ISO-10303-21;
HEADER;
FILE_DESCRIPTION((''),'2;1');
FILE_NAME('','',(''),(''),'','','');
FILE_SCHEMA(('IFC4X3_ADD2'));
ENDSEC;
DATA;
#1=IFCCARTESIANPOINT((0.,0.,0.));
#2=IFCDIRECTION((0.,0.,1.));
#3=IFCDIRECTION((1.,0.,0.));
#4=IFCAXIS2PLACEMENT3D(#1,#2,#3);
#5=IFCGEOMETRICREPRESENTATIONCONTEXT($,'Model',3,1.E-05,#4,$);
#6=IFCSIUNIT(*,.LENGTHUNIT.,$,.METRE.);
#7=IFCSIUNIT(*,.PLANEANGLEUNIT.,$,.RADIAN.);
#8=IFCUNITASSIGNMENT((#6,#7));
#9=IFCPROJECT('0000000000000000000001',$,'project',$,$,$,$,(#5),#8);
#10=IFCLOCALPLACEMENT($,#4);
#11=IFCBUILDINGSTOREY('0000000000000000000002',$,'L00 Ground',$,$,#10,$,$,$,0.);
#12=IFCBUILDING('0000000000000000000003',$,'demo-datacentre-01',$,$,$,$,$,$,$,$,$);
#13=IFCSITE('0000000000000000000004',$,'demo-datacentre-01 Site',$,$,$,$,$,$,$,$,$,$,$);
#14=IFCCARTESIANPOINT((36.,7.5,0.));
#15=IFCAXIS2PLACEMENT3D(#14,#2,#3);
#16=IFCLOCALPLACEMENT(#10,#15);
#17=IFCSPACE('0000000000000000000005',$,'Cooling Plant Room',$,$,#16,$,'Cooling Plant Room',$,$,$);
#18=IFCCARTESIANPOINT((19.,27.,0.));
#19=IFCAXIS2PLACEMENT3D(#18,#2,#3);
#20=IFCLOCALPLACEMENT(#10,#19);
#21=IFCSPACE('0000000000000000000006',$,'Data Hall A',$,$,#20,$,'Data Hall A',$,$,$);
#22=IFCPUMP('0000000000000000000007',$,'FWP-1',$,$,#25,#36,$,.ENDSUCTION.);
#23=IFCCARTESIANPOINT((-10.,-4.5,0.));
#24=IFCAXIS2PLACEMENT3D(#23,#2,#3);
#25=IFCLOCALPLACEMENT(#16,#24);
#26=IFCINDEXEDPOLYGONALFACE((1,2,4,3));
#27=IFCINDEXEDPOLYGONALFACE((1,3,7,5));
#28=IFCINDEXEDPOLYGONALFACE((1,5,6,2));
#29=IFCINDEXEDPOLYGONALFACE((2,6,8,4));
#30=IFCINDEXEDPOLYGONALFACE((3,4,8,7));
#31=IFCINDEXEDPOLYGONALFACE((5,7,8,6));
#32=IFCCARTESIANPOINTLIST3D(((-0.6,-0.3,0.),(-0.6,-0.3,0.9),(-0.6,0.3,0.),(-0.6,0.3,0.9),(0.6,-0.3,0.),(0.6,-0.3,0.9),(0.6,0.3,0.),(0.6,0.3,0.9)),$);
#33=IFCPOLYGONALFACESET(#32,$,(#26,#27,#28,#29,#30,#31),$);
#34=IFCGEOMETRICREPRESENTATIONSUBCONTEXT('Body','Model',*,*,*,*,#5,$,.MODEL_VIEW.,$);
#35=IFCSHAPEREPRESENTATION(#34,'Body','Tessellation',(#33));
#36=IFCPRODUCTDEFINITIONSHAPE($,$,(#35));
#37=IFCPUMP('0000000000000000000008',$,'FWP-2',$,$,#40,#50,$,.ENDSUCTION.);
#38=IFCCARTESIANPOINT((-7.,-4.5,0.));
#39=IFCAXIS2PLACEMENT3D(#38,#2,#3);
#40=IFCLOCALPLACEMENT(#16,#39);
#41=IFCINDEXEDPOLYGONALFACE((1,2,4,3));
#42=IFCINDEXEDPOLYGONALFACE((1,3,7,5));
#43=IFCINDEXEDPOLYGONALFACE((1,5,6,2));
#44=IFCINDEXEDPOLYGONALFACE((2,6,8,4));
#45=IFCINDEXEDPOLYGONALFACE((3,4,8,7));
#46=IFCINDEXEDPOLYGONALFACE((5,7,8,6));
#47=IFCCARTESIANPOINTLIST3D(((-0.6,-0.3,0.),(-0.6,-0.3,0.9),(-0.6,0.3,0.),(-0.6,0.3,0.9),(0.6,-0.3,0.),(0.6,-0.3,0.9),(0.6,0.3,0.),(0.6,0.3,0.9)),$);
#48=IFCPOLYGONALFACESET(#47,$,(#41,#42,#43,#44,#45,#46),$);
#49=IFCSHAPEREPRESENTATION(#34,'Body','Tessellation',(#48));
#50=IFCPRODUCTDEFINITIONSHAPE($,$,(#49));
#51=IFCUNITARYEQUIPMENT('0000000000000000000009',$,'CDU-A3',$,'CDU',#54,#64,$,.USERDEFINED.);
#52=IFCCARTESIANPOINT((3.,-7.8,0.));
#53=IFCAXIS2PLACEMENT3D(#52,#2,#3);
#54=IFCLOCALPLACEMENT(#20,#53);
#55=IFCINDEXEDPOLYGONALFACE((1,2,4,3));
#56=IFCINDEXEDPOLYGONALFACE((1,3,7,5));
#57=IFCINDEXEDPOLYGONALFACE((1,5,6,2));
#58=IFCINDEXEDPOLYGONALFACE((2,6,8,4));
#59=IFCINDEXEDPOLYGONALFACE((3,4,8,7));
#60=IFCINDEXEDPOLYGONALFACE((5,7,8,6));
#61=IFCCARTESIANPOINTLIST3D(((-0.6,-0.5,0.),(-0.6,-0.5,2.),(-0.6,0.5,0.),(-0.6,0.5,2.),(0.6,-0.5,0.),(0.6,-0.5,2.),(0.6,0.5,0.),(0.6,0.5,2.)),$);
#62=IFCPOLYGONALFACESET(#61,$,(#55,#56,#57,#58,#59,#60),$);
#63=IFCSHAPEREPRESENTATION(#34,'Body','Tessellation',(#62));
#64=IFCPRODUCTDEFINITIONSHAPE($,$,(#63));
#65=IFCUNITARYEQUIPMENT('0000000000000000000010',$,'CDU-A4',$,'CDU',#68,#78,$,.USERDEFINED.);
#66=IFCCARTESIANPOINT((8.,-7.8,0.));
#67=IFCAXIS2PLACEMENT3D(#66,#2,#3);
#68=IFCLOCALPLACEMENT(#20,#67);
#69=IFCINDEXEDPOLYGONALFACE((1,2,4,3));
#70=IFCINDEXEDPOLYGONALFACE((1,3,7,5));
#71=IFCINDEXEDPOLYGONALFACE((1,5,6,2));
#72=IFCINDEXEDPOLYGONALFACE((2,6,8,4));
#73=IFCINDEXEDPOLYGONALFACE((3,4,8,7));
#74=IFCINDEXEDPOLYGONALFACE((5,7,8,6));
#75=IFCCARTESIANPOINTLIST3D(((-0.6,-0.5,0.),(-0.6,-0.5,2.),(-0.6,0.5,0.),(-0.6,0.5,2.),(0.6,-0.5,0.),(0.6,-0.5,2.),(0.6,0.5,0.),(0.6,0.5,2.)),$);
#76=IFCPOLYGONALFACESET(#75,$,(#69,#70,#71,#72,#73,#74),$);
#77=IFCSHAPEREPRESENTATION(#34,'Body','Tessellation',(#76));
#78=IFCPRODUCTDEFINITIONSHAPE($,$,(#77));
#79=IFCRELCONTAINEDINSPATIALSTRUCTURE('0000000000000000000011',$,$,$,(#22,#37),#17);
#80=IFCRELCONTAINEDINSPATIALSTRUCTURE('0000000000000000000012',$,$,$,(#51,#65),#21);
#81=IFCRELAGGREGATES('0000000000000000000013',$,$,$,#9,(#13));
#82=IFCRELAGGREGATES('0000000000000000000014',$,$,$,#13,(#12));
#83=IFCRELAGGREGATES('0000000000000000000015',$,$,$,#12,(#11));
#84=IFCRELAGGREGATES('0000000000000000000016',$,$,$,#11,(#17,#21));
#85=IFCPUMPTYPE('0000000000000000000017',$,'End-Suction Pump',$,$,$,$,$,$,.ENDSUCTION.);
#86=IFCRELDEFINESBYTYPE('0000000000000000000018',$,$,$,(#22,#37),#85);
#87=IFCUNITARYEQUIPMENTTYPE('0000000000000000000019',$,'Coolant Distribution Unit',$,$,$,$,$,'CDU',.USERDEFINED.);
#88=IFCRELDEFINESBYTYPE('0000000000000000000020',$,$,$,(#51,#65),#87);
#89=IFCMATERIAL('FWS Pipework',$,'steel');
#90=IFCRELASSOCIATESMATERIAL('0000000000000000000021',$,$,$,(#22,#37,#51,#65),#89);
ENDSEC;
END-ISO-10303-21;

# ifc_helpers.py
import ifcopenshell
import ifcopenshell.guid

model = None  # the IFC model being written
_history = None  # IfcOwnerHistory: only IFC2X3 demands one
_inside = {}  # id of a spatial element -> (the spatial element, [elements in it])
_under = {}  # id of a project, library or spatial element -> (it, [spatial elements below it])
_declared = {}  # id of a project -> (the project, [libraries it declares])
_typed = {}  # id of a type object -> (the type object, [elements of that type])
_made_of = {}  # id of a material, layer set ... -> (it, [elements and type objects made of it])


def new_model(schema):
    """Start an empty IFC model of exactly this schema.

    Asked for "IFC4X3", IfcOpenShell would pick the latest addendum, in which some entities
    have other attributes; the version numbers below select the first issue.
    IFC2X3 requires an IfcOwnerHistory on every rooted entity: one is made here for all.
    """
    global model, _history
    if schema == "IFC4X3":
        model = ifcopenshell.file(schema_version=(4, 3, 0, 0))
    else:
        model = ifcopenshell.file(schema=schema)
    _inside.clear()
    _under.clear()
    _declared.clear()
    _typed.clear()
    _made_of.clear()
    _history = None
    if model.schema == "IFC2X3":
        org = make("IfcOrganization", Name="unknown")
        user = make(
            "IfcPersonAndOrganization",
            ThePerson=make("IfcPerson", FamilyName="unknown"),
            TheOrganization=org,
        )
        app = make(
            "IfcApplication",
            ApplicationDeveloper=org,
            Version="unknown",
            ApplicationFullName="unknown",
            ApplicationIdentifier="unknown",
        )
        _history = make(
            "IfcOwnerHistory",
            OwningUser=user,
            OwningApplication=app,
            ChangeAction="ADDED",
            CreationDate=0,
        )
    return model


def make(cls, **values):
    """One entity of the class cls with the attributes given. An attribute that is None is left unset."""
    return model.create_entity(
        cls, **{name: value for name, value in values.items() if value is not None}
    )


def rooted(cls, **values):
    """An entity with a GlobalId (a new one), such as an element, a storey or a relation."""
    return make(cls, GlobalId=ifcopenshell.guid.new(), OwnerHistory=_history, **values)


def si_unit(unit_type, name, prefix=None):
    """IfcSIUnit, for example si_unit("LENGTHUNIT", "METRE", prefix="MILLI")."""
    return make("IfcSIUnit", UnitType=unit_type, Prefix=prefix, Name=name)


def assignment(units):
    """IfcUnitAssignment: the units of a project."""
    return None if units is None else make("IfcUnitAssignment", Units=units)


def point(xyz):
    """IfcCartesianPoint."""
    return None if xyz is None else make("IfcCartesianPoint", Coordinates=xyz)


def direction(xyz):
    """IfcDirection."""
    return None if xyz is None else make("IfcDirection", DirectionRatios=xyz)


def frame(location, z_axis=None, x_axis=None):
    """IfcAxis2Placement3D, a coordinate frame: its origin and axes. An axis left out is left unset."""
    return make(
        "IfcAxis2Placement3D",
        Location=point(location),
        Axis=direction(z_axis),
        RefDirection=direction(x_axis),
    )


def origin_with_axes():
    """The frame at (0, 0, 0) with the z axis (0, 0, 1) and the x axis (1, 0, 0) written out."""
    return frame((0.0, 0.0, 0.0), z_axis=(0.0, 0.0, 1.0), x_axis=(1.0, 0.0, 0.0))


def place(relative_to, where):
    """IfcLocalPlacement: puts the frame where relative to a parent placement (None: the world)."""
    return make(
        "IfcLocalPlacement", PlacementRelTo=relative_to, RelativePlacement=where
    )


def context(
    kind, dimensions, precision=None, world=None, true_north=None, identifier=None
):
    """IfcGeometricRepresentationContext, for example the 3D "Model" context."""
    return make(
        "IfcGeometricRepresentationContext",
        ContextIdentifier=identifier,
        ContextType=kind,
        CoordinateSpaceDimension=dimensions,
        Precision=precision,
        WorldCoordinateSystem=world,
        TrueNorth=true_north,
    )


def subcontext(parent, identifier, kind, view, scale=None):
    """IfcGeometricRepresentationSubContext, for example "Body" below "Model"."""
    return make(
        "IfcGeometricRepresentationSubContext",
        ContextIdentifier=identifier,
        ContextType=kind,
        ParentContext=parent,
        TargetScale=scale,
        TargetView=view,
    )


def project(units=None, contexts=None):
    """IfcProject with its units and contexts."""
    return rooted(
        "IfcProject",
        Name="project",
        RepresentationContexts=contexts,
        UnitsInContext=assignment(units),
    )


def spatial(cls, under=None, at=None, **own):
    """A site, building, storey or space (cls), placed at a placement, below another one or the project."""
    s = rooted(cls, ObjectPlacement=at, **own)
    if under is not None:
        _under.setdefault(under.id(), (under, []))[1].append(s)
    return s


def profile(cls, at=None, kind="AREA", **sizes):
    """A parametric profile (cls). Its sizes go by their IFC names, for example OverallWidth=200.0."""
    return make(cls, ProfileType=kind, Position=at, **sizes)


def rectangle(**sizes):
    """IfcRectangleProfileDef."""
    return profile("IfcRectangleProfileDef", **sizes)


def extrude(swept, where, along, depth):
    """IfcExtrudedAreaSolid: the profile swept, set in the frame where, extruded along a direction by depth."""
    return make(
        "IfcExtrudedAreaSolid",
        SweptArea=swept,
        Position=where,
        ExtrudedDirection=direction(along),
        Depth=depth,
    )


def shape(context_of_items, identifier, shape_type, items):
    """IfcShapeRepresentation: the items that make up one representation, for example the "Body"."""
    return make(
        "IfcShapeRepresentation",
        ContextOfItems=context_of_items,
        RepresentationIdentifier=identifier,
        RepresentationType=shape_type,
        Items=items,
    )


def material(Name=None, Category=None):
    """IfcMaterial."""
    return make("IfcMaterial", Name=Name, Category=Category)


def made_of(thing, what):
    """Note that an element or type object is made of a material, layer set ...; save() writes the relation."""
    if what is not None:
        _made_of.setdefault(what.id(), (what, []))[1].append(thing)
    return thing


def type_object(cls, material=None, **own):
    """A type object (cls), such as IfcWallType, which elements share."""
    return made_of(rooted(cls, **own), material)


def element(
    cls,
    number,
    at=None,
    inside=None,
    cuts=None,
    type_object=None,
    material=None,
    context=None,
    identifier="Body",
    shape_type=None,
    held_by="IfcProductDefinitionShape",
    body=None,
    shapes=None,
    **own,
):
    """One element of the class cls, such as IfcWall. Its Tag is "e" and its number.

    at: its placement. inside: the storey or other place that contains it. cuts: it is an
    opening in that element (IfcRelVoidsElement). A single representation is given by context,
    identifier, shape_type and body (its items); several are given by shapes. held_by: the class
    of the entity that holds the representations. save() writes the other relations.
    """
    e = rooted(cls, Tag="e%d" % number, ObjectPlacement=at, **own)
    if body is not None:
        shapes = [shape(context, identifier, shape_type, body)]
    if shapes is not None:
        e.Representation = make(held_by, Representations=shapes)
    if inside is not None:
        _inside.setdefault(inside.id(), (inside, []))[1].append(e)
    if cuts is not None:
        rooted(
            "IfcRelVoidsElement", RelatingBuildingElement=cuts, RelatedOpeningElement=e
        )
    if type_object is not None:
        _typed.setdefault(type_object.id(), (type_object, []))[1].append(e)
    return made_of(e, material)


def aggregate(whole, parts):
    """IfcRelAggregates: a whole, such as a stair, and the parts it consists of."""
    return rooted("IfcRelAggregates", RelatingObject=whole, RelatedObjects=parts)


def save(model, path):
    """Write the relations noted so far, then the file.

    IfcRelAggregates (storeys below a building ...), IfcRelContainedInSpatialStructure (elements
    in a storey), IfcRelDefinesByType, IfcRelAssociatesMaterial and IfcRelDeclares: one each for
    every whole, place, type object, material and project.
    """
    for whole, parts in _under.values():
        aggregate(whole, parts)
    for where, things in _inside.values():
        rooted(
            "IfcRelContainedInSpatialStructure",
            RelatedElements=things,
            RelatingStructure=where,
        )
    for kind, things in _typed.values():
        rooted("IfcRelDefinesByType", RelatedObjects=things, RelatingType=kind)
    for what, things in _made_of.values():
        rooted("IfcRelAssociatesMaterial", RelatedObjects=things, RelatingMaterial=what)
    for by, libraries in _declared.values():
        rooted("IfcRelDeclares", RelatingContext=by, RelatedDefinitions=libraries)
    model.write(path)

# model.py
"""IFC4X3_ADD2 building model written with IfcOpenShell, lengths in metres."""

from ifc_helpers import new_model, si_unit, frame, origin_with_axes, place, context, subcontext, project, spatial, rectangle, extrude, material, type_object, element, save


model = new_model("IFC4X3_ADD2")

# Units and contexts
model_context = context("Model", 3, precision=1e-05, world=origin_with_axes())
body_context = subcontext(model_context, "Body", "Model", "MODEL_VIEW")
ifc_project = project(units=[si_unit("LENGTHUNIT", "METRE"), si_unit("PLANEANGLEUNIT", "RADIAN")], contexts=[model_context])

# Site, building, storey
site = spatial("IfcSite", under=ifc_project, Name="demo-datacentre-01 Site")
building = spatial("IfcBuilding", under=site, Name="demo-datacentre-01")
storey_placement = place(None, origin_with_axes())
storey = spatial("IfcBuildingStorey", under=building, at=storey_placement, Name="L00 Ground", Elevation=0.0)

# Shared definitions
ifc_material_1 = material(Name="FWS Pipework", Category="steel")

# Shared definitions
space_1_placement = place(storey_placement, frame((36.0, 7.5, 0.0), z_axis=(0.0, 0.0, 1.0), x_axis=(1.0, 0.0, 0.0)))
space_1 = spatial("IfcSpace", under=storey, at=space_1_placement, Name="Cooling Plant Room", LongName="Cooling Plant Room")

# Pumps
pump_type = type_object("IfcPumpType", Name="End-Suction Pump", PredefinedType="ENDSUCTION")
for number, where, z_axis, x_axis, name in (
    (1, (-10.0, -4.5, 0.0), (0.0, 0.0, 1.0), (1.0, 0.0, 0.0), "FWP-1"),
    (2, (-7.0, -4.5, 0.0), (0.0, 0.0, 1.0), (1.0, 0.0, 0.0), "FWP-2"),
):
    element("IfcPump", number, at=place(space_1_placement, frame(where, z_axis=z_axis, x_axis=x_axis)), inside=space_1, type_object=pump_type, material=ifc_material_1, Name=name, PredefinedType="ENDSUCTION", context=body_context, shape_type="SweptSolid", body=[
        extrude(rectangle(XDim=1.2, YDim=0.6), origin_with_axes(), (0.0, 0.0, 1.0), 0.9),
    ])

# Shared definitions
space_2_placement = place(storey_placement, frame((19.0, 27.0, 0.0), z_axis=(0.0, 0.0, 1.0), x_axis=(1.0, 0.0, 0.0)))
space_2 = spatial("IfcSpace", under=storey, at=space_2_placement, Name="Data Hall A", LongName="Data Hall A")

# Unitary equipment
unitary_equipment_type_1 = type_object("IfcUnitaryEquipmentType", Name="Coolant Distribution Unit", ElementType="CDU", PredefinedType="USERDEFINED")
for number, where, z_axis, x_axis, name in (
    (3, (3.0, -7.8, 0.0), (0.0, 0.0, 1.0), (1.0, 0.0, 0.0), "CDU-A3"),
    (4, (8.0, -7.8, 0.0), (0.0, 0.0, 1.0), (1.0, 0.0, 0.0), "CDU-A4"),
):
    element("IfcUnitaryEquipment", number, at=place(space_2_placement, frame(where, z_axis=z_axis, x_axis=x_axis)), inside=space_2, type_object=unitary_equipment_type_1, material=ifc_material_1, Name=name, ObjectType="CDU", PredefinedType="USERDEFINED", context=body_context, shape_type="SweptSolid", body=[
        extrude(rectangle(XDim=1.2, YDim=1.0), origin_with_axes(), (0.0, 0.0, 1.0), 2.0),
    ])

save(model, "model.ifc")
